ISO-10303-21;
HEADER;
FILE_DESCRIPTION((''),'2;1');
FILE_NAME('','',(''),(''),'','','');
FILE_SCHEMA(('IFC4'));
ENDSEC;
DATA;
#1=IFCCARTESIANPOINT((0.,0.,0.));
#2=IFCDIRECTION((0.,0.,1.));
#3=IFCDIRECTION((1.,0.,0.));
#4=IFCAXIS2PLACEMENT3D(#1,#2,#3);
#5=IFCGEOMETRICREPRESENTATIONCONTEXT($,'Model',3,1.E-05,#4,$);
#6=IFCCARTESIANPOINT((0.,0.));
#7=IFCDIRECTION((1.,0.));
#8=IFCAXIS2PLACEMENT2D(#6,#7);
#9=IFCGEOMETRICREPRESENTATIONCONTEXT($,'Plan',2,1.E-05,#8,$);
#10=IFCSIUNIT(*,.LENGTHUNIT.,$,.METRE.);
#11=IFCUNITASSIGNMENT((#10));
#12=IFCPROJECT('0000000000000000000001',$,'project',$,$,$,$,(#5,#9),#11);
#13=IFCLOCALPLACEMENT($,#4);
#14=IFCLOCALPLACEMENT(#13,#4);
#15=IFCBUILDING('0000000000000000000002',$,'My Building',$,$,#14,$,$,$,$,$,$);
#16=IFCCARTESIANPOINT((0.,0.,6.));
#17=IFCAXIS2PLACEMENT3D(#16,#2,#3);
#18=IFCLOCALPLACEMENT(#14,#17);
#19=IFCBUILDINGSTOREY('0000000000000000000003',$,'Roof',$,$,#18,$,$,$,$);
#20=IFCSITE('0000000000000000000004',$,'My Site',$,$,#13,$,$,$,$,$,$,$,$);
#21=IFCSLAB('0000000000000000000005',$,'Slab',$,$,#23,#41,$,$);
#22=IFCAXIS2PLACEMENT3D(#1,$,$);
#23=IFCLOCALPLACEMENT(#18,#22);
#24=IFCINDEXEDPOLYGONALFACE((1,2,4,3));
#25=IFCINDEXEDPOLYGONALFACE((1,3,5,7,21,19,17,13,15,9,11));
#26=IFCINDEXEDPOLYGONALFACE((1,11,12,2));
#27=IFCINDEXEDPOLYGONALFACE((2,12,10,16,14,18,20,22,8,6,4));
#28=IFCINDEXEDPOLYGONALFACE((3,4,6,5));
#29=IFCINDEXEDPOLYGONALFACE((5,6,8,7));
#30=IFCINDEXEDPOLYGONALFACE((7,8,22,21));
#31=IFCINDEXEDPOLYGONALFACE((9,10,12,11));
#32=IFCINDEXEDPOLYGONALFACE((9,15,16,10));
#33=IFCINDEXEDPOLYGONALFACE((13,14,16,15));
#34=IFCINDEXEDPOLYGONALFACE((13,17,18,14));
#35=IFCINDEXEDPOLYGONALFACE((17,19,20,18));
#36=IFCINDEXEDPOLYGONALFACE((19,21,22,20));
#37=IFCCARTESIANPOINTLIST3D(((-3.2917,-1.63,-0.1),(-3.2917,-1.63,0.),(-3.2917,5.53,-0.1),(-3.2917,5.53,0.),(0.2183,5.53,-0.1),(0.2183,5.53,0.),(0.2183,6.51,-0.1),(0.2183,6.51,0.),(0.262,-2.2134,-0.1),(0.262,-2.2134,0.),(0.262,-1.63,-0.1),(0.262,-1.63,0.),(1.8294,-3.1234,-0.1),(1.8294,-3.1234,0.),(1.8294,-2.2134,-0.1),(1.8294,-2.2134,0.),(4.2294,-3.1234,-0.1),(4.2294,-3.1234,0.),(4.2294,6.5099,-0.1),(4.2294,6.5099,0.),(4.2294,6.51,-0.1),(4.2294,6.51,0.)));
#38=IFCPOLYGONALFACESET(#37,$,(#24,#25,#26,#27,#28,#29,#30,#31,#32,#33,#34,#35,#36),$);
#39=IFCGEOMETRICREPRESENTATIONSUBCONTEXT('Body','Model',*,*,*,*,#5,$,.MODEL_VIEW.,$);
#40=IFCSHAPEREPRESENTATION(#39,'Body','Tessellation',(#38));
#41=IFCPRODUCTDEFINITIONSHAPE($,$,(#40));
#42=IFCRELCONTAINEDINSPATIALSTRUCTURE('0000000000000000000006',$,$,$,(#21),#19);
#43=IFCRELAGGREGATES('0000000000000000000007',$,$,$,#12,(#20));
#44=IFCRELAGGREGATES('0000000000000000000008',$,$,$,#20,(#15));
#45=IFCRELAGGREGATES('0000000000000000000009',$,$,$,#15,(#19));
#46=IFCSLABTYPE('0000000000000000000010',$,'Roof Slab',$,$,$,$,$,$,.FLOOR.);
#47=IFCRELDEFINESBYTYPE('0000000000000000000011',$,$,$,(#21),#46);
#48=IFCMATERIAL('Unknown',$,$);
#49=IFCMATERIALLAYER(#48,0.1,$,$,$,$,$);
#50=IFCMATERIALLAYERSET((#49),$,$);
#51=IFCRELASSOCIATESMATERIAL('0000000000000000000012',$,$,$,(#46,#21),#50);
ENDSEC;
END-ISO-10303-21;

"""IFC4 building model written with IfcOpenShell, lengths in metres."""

from ifc_helpers import new_model, si_unit, frame, origin_with_axes, origin_2d_with_axis, place, context, subcontext, project, spatial, indexed_curve, outline, extrude, material, layer, layer_set, layer_usage, type_object, element, save


model = new_model("IFC4")

# Units and contexts
model_context = context("Model", 3, precision=1e-05, world=origin_with_axes())
plan_context = context("Plan", 2, precision=1e-05, world=origin_2d_with_axis())
body_context = subcontext(model_context, "Body", "Model", "MODEL_VIEW")
ifc_project = project(units=[si_unit("LENGTHUNIT", "METRE")], contexts=[model_context, plan_context])

# Site, building, storey
site_placement = place(None, origin_with_axes())
site = spatial("IfcSite", under=ifc_project, at=site_placement, Name="My Site")
building_placement = place(site_placement, origin_with_axes())
building = spatial("IfcBuilding", under=site, at=building_placement, Name="My Building")
storey_placement = place(building_placement, frame((0.0, 0.0, 6.0), z_axis=(0.0, 0.0, 1.0), x_axis=(1.0, 0.0, 0.0)))
storey = spatial("IfcBuildingStorey", under=building, at=storey_placement, Name="Roof")

# Slab
ifc_material = material(Name="Unknown")
ifc_layer = layer(ifc_material, 0.1)
ifc_layer_set = layer_set([ifc_layer])
ifc_layer_usage = layer_usage(ifc_layer_set, "AXIS3", "NEGATIVE", -0.1)
slab_type = type_object("IfcSlabType", Name="Roof Slab", PredefinedType="FLOOR", material=ifc_layer_set)
slab_placement = place(storey_placement, frame((4.2294, 6.51, 0.1), z_axis=(0.0, 0.0, 1.0), x_axis=(1.0, 0.0, 0.0)))
element("IfcSlab", 1, at=slab_placement, inside=storey, type_object=slab_type, material=ifc_layer_usage, Name="Slab", context=body_context, shape_type="SweptSolid", body=[
    extrude(outline(indexed_curve([(0.0, 0.0), (-4.0111, 0.0), (-4.0111, -0.98), (-7.5211, -0.98), (-7.5211, -8.14), (-3.9674, -8.14), (-3.9674, -8.7234), (-2.4, -8.7234), (-2.4, -9.6333), (0.0, -9.6333), (0.0, 0.0), (0.0, 0.0)])), frame((0.0, 0.0, -0.1), z_axis=(0.0, 0.0, 1.0), x_axis=(1.0, 0.0, 0.0)), (0.0, 0.0, -1.0), 0.1),
])

save(model, "model.ifc")
